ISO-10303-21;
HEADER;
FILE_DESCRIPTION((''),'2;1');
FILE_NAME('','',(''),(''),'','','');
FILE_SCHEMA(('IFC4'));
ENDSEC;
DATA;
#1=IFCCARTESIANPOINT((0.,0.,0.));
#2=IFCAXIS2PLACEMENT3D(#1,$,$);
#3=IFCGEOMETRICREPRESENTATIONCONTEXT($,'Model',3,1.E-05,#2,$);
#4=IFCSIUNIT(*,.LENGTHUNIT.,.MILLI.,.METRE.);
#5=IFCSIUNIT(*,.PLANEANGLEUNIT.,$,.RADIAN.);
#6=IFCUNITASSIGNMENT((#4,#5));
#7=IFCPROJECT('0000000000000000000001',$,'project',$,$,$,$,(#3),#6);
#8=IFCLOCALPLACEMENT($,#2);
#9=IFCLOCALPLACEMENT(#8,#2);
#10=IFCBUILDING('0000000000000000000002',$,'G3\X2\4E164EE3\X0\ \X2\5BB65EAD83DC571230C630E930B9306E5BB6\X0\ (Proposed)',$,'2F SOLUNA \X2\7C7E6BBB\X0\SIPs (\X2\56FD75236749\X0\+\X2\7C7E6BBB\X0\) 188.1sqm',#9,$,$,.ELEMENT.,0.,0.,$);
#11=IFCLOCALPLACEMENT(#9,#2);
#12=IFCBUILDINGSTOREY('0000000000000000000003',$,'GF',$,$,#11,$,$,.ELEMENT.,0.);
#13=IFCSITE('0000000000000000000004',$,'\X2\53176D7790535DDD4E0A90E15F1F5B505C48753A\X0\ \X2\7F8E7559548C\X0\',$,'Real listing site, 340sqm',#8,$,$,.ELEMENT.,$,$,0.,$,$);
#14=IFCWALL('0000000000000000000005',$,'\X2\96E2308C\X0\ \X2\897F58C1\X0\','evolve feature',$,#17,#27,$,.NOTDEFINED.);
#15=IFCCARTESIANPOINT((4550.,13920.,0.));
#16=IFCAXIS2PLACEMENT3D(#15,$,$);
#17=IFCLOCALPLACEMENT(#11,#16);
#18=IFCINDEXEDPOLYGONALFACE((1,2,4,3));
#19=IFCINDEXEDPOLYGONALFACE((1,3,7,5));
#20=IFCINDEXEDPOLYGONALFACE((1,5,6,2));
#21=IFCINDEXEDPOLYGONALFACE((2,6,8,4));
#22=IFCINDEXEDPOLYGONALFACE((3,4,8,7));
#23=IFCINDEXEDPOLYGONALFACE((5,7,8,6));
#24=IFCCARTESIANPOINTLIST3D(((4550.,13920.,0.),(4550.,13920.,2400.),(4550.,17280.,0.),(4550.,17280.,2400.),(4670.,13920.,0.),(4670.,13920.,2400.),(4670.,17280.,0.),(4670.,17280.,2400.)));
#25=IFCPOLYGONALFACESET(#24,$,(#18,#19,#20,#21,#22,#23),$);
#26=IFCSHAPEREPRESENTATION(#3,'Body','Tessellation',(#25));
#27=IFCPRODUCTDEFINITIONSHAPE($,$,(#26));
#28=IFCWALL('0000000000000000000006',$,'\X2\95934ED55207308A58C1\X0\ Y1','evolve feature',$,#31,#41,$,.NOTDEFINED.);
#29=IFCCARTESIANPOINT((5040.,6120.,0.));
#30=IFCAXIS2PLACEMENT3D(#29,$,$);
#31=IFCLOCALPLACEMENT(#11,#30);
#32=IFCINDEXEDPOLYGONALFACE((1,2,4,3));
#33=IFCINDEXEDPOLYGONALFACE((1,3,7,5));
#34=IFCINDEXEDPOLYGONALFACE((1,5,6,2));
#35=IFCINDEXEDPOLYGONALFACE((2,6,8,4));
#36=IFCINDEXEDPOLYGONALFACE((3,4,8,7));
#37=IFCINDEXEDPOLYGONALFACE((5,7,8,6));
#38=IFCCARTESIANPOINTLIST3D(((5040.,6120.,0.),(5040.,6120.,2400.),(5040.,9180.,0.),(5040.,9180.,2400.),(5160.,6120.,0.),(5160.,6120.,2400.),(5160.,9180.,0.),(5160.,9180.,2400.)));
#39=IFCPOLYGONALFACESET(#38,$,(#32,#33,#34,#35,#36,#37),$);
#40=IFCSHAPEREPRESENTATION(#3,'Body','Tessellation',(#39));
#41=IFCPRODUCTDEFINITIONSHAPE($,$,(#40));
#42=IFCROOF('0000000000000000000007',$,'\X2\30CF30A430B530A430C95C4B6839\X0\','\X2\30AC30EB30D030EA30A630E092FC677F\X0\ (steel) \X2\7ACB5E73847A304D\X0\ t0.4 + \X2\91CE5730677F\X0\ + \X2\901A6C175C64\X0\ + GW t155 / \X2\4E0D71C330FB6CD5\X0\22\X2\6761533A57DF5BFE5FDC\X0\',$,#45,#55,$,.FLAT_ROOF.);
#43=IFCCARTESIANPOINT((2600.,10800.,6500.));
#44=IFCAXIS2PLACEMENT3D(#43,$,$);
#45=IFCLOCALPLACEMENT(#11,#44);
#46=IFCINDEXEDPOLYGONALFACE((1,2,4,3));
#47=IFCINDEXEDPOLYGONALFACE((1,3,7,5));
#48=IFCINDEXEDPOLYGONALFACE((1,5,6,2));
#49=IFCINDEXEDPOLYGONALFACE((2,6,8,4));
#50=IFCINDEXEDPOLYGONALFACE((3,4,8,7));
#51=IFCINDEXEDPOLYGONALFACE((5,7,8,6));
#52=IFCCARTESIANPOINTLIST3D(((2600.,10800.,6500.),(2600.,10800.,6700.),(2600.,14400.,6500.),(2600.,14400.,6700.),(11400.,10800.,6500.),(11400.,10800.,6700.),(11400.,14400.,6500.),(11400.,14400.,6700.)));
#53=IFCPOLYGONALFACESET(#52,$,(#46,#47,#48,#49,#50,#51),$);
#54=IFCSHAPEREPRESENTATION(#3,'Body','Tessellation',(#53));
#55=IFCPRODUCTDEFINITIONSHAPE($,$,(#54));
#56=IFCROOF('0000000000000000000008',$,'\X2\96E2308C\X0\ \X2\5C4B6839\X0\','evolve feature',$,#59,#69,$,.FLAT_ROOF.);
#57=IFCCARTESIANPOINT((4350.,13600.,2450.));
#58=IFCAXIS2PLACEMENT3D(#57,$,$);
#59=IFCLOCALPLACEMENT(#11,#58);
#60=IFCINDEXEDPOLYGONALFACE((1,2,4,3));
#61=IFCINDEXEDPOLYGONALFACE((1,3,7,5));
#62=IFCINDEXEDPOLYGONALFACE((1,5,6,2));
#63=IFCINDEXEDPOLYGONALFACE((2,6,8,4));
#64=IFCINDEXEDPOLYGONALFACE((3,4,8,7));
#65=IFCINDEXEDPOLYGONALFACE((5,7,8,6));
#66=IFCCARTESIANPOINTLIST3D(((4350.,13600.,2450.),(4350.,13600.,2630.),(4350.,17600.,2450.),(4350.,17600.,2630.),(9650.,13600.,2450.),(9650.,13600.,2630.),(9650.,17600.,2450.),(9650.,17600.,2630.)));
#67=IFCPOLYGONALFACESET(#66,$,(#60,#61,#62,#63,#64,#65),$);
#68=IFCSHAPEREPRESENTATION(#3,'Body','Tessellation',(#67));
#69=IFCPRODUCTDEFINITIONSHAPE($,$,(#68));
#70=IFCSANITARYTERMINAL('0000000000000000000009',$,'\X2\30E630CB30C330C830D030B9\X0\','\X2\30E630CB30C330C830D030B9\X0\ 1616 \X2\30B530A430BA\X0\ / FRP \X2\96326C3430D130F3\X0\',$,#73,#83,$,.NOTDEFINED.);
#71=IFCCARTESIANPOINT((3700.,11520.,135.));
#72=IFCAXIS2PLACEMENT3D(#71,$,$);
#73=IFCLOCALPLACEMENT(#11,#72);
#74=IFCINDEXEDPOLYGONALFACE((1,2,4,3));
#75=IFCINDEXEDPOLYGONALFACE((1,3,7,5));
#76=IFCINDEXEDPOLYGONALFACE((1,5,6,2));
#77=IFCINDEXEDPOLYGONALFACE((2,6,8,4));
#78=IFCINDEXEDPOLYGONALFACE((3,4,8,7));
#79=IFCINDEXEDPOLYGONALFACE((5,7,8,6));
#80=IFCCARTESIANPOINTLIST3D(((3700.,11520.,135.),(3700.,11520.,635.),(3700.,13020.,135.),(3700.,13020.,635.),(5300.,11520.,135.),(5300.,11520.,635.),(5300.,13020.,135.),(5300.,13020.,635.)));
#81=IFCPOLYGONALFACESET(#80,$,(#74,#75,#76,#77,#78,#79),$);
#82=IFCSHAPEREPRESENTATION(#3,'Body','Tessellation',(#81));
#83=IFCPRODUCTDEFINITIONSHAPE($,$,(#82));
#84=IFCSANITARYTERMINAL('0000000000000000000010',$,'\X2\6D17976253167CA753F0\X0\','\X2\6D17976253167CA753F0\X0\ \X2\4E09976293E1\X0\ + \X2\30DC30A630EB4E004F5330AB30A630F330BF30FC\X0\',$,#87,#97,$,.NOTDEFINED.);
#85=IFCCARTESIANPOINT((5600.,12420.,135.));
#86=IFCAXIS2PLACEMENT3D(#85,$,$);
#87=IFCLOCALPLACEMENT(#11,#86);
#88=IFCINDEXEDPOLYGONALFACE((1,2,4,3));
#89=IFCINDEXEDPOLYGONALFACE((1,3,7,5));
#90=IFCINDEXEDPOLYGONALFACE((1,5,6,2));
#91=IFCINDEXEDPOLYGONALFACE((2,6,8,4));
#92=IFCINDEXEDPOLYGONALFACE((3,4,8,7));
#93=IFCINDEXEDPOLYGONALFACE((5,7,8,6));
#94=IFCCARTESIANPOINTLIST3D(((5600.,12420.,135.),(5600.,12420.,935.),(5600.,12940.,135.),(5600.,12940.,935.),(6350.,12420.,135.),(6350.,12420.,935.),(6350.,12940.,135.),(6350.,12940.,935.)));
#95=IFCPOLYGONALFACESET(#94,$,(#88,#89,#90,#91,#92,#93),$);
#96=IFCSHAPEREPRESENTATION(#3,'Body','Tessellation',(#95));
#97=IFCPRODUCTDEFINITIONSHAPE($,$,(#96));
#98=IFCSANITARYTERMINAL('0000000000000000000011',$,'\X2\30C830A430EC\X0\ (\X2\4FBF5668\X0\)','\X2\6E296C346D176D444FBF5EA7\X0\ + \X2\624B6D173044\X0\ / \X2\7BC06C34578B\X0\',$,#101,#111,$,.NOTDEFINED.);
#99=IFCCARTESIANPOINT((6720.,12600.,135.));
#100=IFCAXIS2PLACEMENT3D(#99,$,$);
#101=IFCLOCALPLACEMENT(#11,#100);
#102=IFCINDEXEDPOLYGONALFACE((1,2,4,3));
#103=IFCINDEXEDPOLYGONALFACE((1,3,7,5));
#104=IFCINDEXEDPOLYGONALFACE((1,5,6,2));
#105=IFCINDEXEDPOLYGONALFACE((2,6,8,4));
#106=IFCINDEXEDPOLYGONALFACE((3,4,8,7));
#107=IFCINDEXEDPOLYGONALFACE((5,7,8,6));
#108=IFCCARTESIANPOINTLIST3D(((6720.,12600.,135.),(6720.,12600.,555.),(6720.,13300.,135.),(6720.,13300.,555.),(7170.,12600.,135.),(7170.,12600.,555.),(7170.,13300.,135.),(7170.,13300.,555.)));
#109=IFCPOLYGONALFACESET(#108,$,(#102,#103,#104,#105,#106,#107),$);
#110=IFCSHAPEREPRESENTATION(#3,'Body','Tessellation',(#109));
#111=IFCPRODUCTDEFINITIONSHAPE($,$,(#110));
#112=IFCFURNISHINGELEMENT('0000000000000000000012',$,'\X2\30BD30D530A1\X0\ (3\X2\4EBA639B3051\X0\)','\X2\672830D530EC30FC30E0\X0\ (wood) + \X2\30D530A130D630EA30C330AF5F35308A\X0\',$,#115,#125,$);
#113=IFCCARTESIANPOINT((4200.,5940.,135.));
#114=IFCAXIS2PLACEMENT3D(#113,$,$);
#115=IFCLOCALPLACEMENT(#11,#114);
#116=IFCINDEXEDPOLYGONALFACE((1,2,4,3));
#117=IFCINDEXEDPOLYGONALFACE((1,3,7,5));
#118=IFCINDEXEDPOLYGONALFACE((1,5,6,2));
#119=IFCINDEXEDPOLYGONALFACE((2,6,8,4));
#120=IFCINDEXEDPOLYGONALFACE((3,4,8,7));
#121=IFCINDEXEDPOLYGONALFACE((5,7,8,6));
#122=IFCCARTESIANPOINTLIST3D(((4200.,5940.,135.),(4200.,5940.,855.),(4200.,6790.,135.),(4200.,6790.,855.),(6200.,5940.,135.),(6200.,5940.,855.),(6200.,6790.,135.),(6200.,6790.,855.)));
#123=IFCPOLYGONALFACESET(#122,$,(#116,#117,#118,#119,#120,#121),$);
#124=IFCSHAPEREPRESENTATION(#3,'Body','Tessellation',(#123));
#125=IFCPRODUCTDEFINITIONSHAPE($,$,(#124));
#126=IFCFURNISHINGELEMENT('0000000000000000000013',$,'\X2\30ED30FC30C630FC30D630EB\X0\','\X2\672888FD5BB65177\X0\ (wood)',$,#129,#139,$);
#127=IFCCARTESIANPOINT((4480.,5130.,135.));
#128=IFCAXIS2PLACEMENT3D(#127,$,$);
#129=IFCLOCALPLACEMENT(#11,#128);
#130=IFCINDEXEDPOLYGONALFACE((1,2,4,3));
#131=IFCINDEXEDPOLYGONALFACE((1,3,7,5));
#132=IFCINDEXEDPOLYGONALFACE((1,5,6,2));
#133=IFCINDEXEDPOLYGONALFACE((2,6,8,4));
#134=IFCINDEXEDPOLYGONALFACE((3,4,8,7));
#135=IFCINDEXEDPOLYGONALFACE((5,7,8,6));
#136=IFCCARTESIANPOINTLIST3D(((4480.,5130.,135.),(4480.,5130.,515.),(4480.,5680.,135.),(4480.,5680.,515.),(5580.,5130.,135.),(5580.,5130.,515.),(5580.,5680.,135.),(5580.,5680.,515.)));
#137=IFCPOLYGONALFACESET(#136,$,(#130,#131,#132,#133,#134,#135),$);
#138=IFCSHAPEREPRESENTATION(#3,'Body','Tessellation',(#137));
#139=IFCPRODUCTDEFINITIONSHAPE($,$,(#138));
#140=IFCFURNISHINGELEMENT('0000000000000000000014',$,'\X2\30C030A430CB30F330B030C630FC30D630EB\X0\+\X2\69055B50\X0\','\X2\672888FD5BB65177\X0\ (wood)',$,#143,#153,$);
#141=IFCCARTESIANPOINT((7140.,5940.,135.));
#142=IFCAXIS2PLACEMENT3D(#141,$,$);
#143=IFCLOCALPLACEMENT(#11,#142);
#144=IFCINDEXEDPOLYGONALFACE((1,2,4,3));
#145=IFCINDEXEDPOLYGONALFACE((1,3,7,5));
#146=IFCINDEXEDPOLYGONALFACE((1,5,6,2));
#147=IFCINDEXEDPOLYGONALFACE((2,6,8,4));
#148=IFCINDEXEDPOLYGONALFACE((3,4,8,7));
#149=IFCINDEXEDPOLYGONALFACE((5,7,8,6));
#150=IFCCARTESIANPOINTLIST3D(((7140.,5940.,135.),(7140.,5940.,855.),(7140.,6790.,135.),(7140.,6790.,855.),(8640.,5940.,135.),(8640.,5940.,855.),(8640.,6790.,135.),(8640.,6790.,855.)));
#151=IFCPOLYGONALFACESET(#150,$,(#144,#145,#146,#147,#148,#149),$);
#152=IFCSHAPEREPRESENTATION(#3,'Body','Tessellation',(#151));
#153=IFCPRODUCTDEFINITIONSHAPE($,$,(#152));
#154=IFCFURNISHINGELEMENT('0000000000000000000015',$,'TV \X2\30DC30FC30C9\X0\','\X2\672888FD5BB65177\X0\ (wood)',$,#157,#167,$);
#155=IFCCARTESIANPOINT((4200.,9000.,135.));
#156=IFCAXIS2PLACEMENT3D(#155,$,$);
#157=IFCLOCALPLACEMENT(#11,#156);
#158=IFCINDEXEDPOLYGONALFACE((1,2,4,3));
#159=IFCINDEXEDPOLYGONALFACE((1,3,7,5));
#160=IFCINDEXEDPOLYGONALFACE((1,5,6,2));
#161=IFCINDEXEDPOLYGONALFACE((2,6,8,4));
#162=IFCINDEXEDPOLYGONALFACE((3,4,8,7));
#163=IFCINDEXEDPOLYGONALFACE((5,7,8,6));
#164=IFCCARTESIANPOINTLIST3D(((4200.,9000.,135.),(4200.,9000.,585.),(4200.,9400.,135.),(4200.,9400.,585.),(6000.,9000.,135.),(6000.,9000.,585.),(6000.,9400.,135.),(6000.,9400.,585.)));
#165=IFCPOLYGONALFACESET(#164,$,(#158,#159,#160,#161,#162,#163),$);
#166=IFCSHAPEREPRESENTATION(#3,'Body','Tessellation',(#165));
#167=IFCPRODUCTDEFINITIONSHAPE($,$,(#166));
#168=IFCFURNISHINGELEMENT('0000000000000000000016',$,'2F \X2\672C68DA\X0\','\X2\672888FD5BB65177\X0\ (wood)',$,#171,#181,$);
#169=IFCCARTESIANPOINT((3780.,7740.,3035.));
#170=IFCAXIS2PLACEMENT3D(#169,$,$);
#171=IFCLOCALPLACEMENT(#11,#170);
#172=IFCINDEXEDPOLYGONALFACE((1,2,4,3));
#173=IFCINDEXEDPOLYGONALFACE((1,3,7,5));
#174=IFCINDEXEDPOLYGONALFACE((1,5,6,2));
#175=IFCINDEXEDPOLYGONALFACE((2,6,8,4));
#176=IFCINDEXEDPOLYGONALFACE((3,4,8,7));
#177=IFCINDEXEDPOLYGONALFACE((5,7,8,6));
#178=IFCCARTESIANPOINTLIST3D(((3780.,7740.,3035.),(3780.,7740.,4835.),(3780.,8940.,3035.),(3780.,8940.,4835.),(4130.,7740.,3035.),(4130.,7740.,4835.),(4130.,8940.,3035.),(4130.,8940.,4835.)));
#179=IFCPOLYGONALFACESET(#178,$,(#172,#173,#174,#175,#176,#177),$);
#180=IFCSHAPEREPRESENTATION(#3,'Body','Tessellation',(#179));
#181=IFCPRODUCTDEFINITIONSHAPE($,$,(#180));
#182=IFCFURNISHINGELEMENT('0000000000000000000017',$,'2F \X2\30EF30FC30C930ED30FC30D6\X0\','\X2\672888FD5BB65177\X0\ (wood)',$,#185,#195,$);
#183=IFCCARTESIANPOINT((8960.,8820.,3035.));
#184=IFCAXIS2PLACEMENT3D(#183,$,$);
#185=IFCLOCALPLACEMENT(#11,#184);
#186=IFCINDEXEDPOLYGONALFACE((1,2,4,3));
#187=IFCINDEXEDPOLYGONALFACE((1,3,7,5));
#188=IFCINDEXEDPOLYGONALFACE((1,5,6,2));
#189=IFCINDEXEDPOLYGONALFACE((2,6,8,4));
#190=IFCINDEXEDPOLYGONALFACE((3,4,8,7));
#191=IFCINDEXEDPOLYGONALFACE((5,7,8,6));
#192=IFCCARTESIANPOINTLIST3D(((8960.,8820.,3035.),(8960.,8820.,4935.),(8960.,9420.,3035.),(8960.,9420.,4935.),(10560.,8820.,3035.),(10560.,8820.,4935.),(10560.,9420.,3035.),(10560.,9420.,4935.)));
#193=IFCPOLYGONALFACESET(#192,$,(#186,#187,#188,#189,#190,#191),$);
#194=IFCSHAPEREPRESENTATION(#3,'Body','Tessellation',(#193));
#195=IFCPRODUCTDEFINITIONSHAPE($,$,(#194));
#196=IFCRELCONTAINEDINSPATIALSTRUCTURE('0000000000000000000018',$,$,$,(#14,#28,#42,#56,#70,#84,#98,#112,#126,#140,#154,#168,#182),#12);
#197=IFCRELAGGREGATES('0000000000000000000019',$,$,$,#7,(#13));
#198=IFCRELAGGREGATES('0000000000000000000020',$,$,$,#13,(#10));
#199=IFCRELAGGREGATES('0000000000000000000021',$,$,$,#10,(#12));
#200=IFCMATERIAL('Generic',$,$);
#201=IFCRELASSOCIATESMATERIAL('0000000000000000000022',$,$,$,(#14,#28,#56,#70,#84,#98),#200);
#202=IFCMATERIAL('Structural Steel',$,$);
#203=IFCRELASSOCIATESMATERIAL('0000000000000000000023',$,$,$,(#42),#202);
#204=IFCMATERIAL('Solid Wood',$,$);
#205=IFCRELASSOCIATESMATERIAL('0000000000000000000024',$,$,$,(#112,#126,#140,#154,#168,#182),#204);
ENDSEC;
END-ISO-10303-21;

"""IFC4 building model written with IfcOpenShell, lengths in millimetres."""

from ifc_helpers import new_model, si_unit, frame, frame_2d, origin, place, context, project, spatial, rectangle, extrude, material, element, save


model = new_model("IFC4")

# Units and contexts
model_context = context("Model", 3, precision=1e-05, world=origin())
ifc_project = project(units=[si_unit("LENGTHUNIT", "METRE", prefix="MILLI"), si_unit("PLANEANGLEUNIT", "RADIAN")], contexts=[model_context])

# Site, building, storey
site_placement = place(None, origin())
site = spatial("IfcSite", under=ifc_project, at=site_placement, Name="北海道川上郡弟子屈町 美留和", ObjectType="Real listing site, 340sqm", CompositionType="ELEMENT", RefElevation=0.0)
building_placement = place(site_placement, origin())
building = spatial("IfcBuilding", under=site, at=building_placement, Name="G3世代 家庭菜園テラスの家 (Proposed)", ObjectType="2F SOLUNA 籾殻SIPs (国産杉+籾殻) 188.1sqm", CompositionType="ELEMENT", ElevationOfRefHeight=0.0, ElevationOfTerrain=0.0)
storey_placement = place(building_placement, origin())
storey = spatial("IfcBuildingStorey", under=building, at=storey_placement, Name="GF", CompositionType="ELEMENT", Elevation=0.0)

# Shared definitions
ifc_material_1 = material(Name="Generic")

# Shared definitions
ifc_material_2 = material(Name="Solid Wood")

# Walls
wall_1_placement = place(storey_placement, frame((4550.0, 13920.0, 0.0)))
element("IfcWall", 1, at=wall_1_placement, inside=storey, material=ifc_material_1, Name="離れ 西壁", Description="evolve feature", PredefinedType="NOTDEFINED", context=model_context, shape_type="SweptSolid", body=[
    extrude(rectangle(XDim=120.0, YDim=3360.0, at=frame_2d((60.0, 1680.0))), frame((4550.0, 13920.0, 0.0)), (0.0, 0.0, 1.0), 2400.0),
])
wall_2_placement = place(storey_placement, frame((5040.0, 6120.0, 0.0)))
element("IfcWall", 2, at=wall_2_placement, inside=storey, material=ifc_material_1, Name="間仕切り壁 Y1", Description="evolve feature", PredefinedType="NOTDEFINED", context=model_context, shape_type="SweptSolid", body=[
    extrude(rectangle(XDim=120.0, YDim=3060.0, at=frame_2d((60.0, 1530.0))), frame((5040.0, 6120.0, 0.0)), (0.0, 0.0, 1.0), 2400.0),
])

# Roofs
ifc_material_3 = material(Name="Structural Steel")
roof_1_placement = place(storey_placement, frame((2600.0, 10800.0, 6500.0)))
element("IfcRoof", 3, at=roof_1_placement, inside=storey, material=ifc_material_3, Name="ハイサイド屋根", Description="ガルバリウム鋼板 (steel) 立平葺き t0.4 + 野地板 + 通気層 + GW t155 / 不燃・法22条区域対応", PredefinedType="FLAT_ROOF", context=model_context, shape_type="SweptSolid", body=[
    extrude(rectangle(XDim=8800.0, YDim=3600.0, at=frame_2d((4400.0, 1800.0))), frame((2600.0, 10800.0, 6500.0)), (0.0, 0.0, 1.0), 200.0),
])
roof_2_placement = place(storey_placement, frame((4350.0, 13600.0, 2450.0)))
element("IfcRoof", 4, at=roof_2_placement, inside=storey, material=ifc_material_1, Name="離れ 屋根", Description="evolve feature", PredefinedType="FLAT_ROOF", context=model_context, shape_type="SweptSolid", body=[
    extrude(rectangle(XDim=5300.0, YDim=4000.0, at=frame_2d((2650.0, 2000.0))), frame((4350.0, 13600.0, 2450.0)), (0.0, 0.0, 1.0), 180.0),
])

# Sanitary terminals
sanitary_terminal_1_placement = place(storey_placement, frame((3700.0, 11520.0, 135.0)))
element("IfcSanitaryTerminal", 5, at=sanitary_terminal_1_placement, inside=storey, material=ifc_material_1, Name="ユニットバス", Description="ユニットバス 1616 サイズ / FRP 防水パン", PredefinedType="NOTDEFINED", context=model_context, shape_type="SweptSolid", body=[
    extrude(rectangle(XDim=1600.0, YDim=1500.0, at=frame_2d((800.0, 750.0))), frame((3700.0, 11520.0, 135.0)), (0.0, 0.0, 1.0), 500.0),
])
sanitary_terminal_2_placement = place(storey_placement, frame((5600.0, 12420.0, 135.0)))
element("IfcSanitaryTerminal", 6, at=sanitary_terminal_2_placement, inside=storey, material=ifc_material_1, Name="洗面化粧台", Description="洗面化粧台 三面鏡 + ボウル一体カウンター", PredefinedType="NOTDEFINED", context=model_context, shape_type="SweptSolid", body=[
    extrude(rectangle(XDim=750.0, YDim=520.0, at=frame_2d((375.0, 260.0))), frame((5600.0, 12420.0, 135.0)), (0.0, 0.0, 1.0), 800.0),
])
sanitary_terminal_3_placement = place(storey_placement, frame((6720.0, 12600.0, 135.0)))
element("IfcSanitaryTerminal", 7, at=sanitary_terminal_3_placement, inside=storey, material=ifc_material_1, Name="トイレ (便器)", Description="温水洗浄便座 + 手洗い / 節水型", PredefinedType="NOTDEFINED", context=model_context, shape_type="SweptSolid", body=[
    extrude(rectangle(XDim=450.0, YDim=700.0, at=frame_2d((225.0, 350.0))), frame((6720.0, 12600.0, 135.0)), (0.0, 0.0, 1.0), 420.0),
])

# Furnishing elements
furnishing_1_placement = place(storey_placement, frame((4200.0, 5940.0, 135.0)))
element("IfcFurnishingElement", 8, at=furnishing_1_placement, inside=storey, material=ifc_material_2, Name="ソファ (3人掛け)", Description="木フレーム (wood) + ファブリック張り", context=model_context, shape_type="SweptSolid", body=[
    extrude(rectangle(XDim=2000.0, YDim=850.0, at=frame_2d((1000.0, 425.0))), frame((4200.0, 5940.0, 135.0)), (0.0, 0.0, 1.0), 720.0),
])
furnishing_2_placement = place(storey_placement, frame((4480.0, 5130.0, 135.0)))
element("IfcFurnishingElement", 9, at=furnishing_2_placement, inside=storey, material=ifc_material_2, Name="ローテーブル", Description="木製家具 (wood)", context=model_context, shape_type="SweptSolid", body=[
    extrude(rectangle(XDim=1100.0, YDim=550.0, at=frame_2d((550.0, 275.0))), frame((4480.0, 5130.0, 135.0)), (0.0, 0.0, 1.0), 380.0),
])
furnishing_3_placement = place(storey_placement, frame((7140.0, 5940.0, 135.0)))
element("IfcFurnishingElement", 10, at=furnishing_3_placement, inside=storey, material=ifc_material_2, Name="ダイニングテーブル+椅子", Description="木製家具 (wood)", context=model_context, shape_type="SweptSolid", body=[
    extrude(rectangle(XDim=1500.0, YDim=850.0, at=frame_2d((750.0, 425.0))), frame((7140.0, 5940.0, 135.0)), (0.0, 0.0, 1.0), 720.0),
])
furnishing_4_placement = place(storey_placement, frame((4200.0, 9000.0, 135.0)))
element("IfcFurnishingElement", 11, at=furnishing_4_placement, inside=storey, material=ifc_material_2, Name="TV ボード", Description="木製家具 (wood)", context=model_context, shape_type="SweptSolid", body=[
    extrude(rectangle(XDim=1800.0, YDim=400.0, at=frame_2d((900.0, 200.0))), frame((4200.0, 9000.0, 135.0)), (0.0, 0.0, 1.0), 450.0),
])
furnishing_5_placement = place(storey_placement, frame((3780.0, 7740.0, 3035.0)))
element("IfcFurnishingElement", 12, at=furnishing_5_placement, inside=storey, material=ifc_material_2, Name="2F 本棚", Description="木製家具 (wood)", context=model_context, shape_type="SweptSolid", body=[
    extrude(rectangle(XDim=350.0, YDim=1200.0, at=frame_2d((175.0, 600.0))), frame((3780.0, 7740.0, 3035.0)), (0.0, 0.0, 1.0), 1800.0),
])
furnishing_6_placement = place(storey_placement, frame((8960.0, 8820.0, 3035.0)))
element("IfcFurnishingElement", 13, at=furnishing_6_placement, inside=storey, material=ifc_material_2, Name="2F ワードローブ", Description="木製家具 (wood)", context=model_context, shape_type="SweptSolid", body=[
    extrude(rectangle(XDim=1600.0, YDim=600.0, at=frame_2d((800.0, 300.0))), frame((8960.0, 8820.0, 3035.0)), (0.0, 0.0, 1.0), 1900.0),
])

save(model, "model.ifc")
